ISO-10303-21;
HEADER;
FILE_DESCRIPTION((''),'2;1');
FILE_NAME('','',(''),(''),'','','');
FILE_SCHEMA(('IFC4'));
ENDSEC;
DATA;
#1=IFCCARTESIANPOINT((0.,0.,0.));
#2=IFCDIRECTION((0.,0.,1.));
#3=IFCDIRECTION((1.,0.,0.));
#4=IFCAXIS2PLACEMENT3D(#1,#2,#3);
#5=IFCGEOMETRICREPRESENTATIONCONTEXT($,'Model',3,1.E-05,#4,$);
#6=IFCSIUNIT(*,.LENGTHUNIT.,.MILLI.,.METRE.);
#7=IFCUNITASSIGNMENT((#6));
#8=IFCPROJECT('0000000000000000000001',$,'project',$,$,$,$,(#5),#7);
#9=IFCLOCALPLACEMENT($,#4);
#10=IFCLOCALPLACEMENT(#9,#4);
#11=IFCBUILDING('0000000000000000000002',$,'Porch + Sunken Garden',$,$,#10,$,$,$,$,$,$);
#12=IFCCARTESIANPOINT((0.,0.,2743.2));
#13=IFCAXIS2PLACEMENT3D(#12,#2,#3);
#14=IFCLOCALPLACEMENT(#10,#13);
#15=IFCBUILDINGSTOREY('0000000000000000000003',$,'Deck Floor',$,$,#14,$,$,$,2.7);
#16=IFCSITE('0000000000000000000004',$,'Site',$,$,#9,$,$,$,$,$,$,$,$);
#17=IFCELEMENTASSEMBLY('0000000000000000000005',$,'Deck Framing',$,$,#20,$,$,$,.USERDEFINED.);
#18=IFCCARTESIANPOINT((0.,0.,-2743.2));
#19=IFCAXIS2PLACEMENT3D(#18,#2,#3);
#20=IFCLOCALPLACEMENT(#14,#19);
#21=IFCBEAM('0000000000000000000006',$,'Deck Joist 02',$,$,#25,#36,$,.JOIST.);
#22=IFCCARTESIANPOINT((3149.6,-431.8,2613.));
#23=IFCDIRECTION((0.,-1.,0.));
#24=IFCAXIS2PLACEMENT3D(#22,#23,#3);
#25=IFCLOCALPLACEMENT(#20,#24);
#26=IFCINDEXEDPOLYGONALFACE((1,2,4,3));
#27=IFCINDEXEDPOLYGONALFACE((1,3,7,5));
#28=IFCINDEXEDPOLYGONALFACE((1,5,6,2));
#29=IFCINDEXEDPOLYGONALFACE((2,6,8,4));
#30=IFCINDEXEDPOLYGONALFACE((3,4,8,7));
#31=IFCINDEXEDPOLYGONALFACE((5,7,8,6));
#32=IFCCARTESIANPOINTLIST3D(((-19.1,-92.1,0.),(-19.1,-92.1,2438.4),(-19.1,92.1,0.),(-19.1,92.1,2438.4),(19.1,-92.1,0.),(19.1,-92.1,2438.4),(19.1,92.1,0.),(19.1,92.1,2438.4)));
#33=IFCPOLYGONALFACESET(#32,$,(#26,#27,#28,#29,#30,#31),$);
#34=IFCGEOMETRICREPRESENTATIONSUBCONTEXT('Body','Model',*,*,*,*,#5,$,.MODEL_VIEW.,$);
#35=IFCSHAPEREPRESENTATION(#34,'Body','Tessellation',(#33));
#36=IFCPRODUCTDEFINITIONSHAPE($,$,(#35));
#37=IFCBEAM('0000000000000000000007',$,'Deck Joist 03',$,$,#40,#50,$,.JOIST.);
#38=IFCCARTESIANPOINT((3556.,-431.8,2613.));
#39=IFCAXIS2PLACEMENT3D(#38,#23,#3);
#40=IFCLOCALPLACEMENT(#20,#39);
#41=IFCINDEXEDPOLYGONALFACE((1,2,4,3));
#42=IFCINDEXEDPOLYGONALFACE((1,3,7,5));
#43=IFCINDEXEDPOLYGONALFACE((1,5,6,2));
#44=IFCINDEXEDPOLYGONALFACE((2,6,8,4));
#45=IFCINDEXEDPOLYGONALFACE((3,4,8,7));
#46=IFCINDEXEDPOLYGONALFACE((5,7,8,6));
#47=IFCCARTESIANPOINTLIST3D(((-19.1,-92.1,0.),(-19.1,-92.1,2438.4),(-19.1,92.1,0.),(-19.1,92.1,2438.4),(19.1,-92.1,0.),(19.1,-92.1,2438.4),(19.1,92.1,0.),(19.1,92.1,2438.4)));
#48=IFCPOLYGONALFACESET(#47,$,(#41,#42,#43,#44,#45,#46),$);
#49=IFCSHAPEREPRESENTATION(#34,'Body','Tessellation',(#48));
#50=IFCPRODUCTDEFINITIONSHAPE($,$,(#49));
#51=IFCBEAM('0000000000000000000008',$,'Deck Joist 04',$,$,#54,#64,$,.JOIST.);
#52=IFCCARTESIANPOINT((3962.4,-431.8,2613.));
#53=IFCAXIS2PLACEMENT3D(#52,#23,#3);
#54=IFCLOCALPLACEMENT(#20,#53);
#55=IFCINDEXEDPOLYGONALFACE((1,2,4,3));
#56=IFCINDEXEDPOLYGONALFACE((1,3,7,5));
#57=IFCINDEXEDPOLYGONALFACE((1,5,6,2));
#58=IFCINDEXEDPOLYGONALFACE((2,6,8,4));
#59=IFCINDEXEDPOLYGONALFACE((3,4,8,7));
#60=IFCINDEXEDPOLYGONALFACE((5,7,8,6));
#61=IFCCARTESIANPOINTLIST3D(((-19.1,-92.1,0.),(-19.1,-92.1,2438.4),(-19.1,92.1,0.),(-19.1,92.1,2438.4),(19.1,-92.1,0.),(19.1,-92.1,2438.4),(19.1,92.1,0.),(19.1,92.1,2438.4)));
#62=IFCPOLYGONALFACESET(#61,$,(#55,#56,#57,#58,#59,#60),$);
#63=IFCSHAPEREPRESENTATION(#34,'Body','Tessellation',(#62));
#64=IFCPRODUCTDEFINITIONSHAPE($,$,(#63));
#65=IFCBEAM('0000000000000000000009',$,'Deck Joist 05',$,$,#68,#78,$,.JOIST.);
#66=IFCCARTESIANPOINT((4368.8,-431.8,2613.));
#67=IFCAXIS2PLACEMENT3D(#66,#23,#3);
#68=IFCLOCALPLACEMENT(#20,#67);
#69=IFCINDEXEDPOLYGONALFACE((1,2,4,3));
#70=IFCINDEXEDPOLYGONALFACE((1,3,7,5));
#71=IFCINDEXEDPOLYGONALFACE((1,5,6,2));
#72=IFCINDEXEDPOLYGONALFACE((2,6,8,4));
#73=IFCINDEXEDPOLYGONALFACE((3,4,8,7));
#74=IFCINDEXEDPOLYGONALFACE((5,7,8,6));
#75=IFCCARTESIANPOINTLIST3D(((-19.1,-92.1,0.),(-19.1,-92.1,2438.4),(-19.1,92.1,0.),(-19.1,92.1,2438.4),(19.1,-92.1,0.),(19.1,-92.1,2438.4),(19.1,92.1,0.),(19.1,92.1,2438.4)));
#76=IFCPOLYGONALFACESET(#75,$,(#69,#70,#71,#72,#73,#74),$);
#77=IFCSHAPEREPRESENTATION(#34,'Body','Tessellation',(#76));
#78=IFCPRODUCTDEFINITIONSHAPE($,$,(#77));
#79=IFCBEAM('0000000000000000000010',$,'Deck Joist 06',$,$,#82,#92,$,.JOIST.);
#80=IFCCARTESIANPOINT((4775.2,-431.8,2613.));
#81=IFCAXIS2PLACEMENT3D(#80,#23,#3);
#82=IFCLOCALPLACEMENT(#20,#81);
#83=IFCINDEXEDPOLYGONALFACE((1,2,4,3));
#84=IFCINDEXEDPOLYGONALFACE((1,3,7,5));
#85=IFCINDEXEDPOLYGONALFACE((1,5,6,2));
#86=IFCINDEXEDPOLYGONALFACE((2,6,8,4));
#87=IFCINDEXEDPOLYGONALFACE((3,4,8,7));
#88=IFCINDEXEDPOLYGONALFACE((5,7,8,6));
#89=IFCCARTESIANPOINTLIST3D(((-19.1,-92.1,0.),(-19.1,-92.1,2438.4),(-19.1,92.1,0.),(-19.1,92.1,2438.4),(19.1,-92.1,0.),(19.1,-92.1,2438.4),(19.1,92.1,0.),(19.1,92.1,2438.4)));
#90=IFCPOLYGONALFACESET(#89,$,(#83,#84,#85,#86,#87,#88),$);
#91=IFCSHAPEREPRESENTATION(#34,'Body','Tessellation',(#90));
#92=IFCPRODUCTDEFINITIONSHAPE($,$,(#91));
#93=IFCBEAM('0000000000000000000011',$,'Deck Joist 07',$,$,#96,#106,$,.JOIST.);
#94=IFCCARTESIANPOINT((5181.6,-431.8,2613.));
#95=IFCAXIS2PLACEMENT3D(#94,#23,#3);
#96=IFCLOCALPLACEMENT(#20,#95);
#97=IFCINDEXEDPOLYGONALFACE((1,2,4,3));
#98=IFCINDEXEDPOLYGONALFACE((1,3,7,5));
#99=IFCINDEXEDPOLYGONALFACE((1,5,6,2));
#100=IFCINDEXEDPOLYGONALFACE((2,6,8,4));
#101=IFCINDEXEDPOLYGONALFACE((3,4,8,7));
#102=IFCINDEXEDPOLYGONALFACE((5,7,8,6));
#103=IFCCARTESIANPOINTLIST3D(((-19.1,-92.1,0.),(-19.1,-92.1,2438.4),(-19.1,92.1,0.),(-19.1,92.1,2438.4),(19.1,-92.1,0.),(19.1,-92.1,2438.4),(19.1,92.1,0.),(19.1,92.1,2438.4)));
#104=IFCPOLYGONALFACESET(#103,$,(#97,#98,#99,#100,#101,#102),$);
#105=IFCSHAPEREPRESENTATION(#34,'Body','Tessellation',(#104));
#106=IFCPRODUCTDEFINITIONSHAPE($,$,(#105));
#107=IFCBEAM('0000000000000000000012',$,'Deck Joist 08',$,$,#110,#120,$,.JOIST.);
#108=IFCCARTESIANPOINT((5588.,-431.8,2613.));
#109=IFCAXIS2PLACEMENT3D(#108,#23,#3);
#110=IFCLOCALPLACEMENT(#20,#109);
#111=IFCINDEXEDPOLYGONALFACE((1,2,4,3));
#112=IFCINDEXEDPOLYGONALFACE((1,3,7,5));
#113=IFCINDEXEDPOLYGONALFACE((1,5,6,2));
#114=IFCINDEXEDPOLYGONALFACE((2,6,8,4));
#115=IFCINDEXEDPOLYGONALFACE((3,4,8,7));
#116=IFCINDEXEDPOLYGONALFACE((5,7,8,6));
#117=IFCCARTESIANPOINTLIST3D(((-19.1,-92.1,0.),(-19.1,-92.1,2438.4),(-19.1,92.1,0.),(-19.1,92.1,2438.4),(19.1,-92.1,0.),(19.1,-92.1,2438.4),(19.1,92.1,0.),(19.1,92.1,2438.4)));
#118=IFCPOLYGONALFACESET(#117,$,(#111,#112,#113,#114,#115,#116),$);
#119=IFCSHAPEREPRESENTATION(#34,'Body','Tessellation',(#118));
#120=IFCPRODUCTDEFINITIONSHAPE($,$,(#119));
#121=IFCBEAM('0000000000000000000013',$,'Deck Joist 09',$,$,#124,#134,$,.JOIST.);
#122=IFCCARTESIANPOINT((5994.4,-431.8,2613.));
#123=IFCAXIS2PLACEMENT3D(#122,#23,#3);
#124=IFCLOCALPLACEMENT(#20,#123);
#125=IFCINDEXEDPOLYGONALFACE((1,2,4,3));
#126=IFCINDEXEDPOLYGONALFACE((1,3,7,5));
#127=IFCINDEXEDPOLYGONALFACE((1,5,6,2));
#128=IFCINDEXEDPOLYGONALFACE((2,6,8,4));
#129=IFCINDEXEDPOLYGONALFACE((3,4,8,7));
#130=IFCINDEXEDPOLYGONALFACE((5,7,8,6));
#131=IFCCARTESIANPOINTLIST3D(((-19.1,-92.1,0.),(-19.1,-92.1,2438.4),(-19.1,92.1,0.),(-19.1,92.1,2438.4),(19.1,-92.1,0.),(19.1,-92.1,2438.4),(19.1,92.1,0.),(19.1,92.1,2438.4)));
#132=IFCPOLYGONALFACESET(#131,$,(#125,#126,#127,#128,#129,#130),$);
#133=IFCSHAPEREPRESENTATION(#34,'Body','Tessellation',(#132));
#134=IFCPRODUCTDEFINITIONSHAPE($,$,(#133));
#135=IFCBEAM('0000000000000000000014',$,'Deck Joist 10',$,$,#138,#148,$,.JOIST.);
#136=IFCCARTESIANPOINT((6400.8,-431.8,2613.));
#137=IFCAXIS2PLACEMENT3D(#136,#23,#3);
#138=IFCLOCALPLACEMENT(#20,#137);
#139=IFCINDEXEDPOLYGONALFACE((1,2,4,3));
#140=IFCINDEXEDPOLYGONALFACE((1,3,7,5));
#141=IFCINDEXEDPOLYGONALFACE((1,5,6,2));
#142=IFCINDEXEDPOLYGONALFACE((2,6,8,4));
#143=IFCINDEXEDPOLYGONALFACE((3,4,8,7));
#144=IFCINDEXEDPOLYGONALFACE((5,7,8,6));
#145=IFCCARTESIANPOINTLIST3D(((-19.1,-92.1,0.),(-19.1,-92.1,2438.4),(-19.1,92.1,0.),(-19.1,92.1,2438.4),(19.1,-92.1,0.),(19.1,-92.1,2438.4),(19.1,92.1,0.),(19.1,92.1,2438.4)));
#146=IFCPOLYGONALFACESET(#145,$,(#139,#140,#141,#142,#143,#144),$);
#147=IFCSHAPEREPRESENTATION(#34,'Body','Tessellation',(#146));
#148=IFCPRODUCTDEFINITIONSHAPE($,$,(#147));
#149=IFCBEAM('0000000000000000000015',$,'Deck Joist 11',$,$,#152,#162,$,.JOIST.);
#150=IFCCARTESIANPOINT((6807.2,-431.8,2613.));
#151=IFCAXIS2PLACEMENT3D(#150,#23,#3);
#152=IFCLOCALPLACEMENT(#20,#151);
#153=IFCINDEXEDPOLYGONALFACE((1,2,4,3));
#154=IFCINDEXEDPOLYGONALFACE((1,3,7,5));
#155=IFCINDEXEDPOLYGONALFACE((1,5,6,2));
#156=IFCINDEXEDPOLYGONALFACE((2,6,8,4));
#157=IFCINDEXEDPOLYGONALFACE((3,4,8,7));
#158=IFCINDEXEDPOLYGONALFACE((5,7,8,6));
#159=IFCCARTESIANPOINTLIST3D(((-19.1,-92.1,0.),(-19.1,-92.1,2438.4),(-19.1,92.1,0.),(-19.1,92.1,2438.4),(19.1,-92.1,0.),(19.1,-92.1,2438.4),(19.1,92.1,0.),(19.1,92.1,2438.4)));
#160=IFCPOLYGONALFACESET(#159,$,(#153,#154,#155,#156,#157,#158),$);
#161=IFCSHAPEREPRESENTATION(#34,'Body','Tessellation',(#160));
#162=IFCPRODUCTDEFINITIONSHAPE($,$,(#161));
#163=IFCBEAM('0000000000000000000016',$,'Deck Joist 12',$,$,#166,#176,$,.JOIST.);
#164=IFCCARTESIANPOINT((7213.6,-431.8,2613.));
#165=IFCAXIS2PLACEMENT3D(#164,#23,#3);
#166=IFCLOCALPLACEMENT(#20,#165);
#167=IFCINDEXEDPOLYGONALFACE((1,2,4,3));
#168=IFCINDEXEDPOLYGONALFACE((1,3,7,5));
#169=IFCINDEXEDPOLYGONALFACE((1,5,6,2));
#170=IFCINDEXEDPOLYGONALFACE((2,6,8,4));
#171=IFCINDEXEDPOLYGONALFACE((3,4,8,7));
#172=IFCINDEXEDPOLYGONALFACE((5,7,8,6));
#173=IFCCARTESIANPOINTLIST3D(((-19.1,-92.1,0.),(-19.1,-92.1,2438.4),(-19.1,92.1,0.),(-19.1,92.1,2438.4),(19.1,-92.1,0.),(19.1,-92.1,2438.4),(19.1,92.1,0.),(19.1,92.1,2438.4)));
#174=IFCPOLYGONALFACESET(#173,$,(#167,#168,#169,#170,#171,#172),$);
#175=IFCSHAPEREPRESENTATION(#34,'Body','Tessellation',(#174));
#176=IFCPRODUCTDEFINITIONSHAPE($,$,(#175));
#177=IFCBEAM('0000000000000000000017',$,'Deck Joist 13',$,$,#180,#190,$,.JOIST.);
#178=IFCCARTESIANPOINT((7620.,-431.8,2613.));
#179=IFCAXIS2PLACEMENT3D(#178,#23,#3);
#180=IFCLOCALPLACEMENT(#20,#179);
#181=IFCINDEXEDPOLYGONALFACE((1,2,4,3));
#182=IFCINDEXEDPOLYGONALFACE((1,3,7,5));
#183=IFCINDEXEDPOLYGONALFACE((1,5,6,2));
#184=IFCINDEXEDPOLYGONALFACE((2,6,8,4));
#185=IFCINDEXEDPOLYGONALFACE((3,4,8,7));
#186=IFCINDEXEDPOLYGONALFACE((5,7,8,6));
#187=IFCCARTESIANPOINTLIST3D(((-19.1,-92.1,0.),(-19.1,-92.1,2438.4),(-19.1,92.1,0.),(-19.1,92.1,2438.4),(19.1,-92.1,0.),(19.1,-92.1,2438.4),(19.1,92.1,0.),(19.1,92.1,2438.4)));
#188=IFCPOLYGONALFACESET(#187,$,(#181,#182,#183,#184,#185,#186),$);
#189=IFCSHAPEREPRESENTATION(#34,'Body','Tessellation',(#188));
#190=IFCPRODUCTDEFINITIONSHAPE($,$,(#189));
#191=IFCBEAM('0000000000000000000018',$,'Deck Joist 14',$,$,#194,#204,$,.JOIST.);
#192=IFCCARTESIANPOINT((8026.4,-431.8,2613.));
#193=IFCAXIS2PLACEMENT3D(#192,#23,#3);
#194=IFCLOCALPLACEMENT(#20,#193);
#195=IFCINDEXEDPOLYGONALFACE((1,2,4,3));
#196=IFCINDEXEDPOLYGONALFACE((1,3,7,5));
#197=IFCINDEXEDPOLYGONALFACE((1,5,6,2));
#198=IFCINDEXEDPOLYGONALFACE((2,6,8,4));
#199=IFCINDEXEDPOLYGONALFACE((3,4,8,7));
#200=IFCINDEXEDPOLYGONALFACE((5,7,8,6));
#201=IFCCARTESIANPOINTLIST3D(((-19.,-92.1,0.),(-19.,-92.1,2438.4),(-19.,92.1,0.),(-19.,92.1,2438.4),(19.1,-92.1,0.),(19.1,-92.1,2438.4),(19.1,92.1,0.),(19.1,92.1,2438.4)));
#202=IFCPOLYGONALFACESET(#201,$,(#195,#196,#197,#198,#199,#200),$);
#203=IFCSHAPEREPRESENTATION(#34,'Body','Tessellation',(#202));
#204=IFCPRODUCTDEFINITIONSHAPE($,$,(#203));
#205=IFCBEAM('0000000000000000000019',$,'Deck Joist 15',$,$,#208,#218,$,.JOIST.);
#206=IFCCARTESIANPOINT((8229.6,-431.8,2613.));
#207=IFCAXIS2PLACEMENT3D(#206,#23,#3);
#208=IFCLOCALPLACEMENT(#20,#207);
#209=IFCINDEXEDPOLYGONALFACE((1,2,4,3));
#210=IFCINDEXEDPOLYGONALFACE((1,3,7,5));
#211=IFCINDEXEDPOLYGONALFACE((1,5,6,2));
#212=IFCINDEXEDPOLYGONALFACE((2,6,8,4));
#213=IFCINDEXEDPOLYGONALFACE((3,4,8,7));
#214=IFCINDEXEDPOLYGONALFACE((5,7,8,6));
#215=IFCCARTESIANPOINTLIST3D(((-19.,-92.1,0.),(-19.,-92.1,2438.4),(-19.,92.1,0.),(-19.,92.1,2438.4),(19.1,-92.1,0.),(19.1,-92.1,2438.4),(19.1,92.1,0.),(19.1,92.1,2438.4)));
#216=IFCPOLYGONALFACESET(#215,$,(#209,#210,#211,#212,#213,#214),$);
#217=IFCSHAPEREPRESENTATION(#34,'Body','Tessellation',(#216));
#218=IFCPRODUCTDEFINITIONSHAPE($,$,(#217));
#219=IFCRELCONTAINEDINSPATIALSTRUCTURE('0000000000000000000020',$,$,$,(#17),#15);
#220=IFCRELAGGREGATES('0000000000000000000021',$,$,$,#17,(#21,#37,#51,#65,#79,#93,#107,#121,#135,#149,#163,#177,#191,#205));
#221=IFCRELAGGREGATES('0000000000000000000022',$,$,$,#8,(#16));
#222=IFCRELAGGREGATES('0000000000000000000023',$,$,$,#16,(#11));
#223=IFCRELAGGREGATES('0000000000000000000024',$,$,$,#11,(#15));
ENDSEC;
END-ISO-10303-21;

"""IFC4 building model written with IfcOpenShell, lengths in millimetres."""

from ifc_helpers import new_model, si_unit, frame, origin_with_axes, origin_2d, place, context, subcontext, project, spatial, rectangle, extrude, element, aggregate, save


model = new_model("IFC4")

# Units and contexts
model_context = context("Model", 3, precision=1e-05, world=origin_with_axes())
body_context = subcontext(model_context, "Body", "Model", "MODEL_VIEW")
ifc_project = project(units=[si_unit("LENGTHUNIT", "METRE", prefix="MILLI")], contexts=[model_context])

# Site, building, storey
site_placement = place(None, origin_with_axes())
site = spatial("IfcSite", under=ifc_project, at=site_placement, Name="Site")
building_placement = place(site_placement, origin_with_axes())
building = spatial("IfcBuilding", under=site, at=building_placement, Name="Porch + Sunken Garden")
storey_placement = place(building_placement, frame((0.0, 0.0, 2743.2), z_axis=(0.0, 0.0, 1.0), x_axis=(1.0, 0.0, 0.0)))
storey = spatial("IfcBuildingStorey", under=building, at=storey_placement, Name="Deck Floor", Elevation=2.7)

# Element assembly, beams
assembly_placement = place(storey_placement, frame((0.0, 0.0, -2743.2), z_axis=(0.0, 0.0, 1.0), x_axis=(1.0, 0.0, 0.0)))
assembly = element("IfcElementAssembly", 1, at=assembly_placement, inside=storey, Name="Deck Framing", PredefinedType="USERDEFINED")
beam_1_placement = place(assembly_placement, frame((3149.6, -431.8, 2613.0), z_axis=(0.0, -1.0, 0.0), x_axis=(1.0, 0.0, 0.0)))
beam_1 = element("IfcBeam", 2, at=beam_1_placement, Name="Deck Joist 02", PredefinedType="JOIST", context=body_context, shape_type="SweptSolid", body=[
    extrude(rectangle(XDim=38.1, YDim=184.2, at=origin_2d()), origin_with_axes(), (0.0, 0.0, 1.0), 2438.4),
])
beam_2_placement = place(assembly_placement, frame((3556.0, -431.8, 2613.0), z_axis=(0.0, -1.0, 0.0), x_axis=(1.0, 0.0, 0.0)))
beam_2 = element("IfcBeam", 3, at=beam_2_placement, Name="Deck Joist 03", PredefinedType="JOIST", context=body_context, shape_type="SweptSolid", body=[
    extrude(rectangle(XDim=38.1, YDim=184.2, at=origin_2d()), origin_with_axes(), (0.0, 0.0, 1.0), 2438.4),
])
beam_3_placement = place(assembly_placement, frame((3962.4, -431.8, 2613.0), z_axis=(0.0, -1.0, 0.0), x_axis=(1.0, 0.0, 0.0)))
beam_3 = element("IfcBeam", 4, at=beam_3_placement, Name="Deck Joist 04", PredefinedType="JOIST", context=body_context, shape_type="SweptSolid", body=[
    extrude(rectangle(XDim=38.1, YDim=184.2, at=origin_2d()), origin_with_axes(), (0.0, 0.0, 1.0), 2438.4),
])
beam_4_placement = place(assembly_placement, frame((4368.8, -431.8, 2613.0), z_axis=(0.0, -1.0, 0.0), x_axis=(1.0, 0.0, 0.0)))
beam_4 = element("IfcBeam", 5, at=beam_4_placement, Name="Deck Joist 05", PredefinedType="JOIST", context=body_context, shape_type="SweptSolid", body=[
    extrude(rectangle(XDim=38.1, YDim=184.2, at=origin_2d()), origin_with_axes(), (0.0, 0.0, 1.0), 2438.4),
])
beam_5_placement = place(assembly_placement, frame((4775.2, -431.8, 2613.0), z_axis=(0.0, -1.0, 0.0), x_axis=(1.0, 0.0, 0.0)))
beam_5 = element("IfcBeam", 6, at=beam_5_placement, Name="Deck Joist 06", PredefinedType="JOIST", context=body_context, shape_type="SweptSolid", body=[
    extrude(rectangle(XDim=38.1, YDim=184.2, at=origin_2d()), origin_with_axes(), (0.0, 0.0, 1.0), 2438.4),
])
beam_6_placement = place(assembly_placement, frame((5181.6, -431.8, 2613.0), z_axis=(0.0, -1.0, 0.0), x_axis=(1.0, 0.0, 0.0)))
beam_6 = element("IfcBeam", 7, at=beam_6_placement, Name="Deck Joist 07", PredefinedType="JOIST", context=body_context, shape_type="SweptSolid", body=[
    extrude(rectangle(XDim=38.1, YDim=184.2, at=origin_2d()), origin_with_axes(), (0.0, 0.0, 1.0), 2438.4),
])
beam_7_placement = place(assembly_placement, frame((5588.0, -431.8, 2613.0), z_axis=(0.0, -1.0, 0.0), x_axis=(1.0, 0.0, 0.0)))
beam_7 = element("IfcBeam", 8, at=beam_7_placement, Name="Deck Joist 08", PredefinedType="JOIST", context=body_context, shape_type="SweptSolid", body=[
    extrude(rectangle(XDim=38.1, YDim=184.2, at=origin_2d()), origin_with_axes(), (0.0, 0.0, 1.0), 2438.4),
])
beam_8_placement = place(assembly_placement, frame((5994.4, -431.8, 2613.0), z_axis=(0.0, -1.0, 0.0), x_axis=(1.0, 0.0, 0.0)))
beam_8 = element("IfcBeam", 9, at=beam_8_placement, Name="Deck Joist 09", PredefinedType="JOIST", context=body_context, shape_type="SweptSolid", body=[
    extrude(rectangle(XDim=38.1, YDim=184.2, at=origin_2d()), origin_with_axes(), (0.0, 0.0, 1.0), 2438.4),
])
beam_9_placement = place(assembly_placement, frame((6400.8, -431.8, 2613.0), z_axis=(0.0, -1.0, 0.0), x_axis=(1.0, 0.0, 0.0)))
beam_9 = element("IfcBeam", 10, at=beam_9_placement, Name="Deck Joist 10", PredefinedType="JOIST", context=body_context, shape_type="SweptSolid", body=[
    extrude(rectangle(XDim=38.1, YDim=184.2, at=origin_2d()), origin_with_axes(), (0.0, 0.0, 1.0), 2438.4),
])
beam_10_placement = place(assembly_placement, frame((6807.2, -431.8, 2613.0), z_axis=(0.0, -1.0, 0.0), x_axis=(1.0, 0.0, 0.0)))
beam_10 = element("IfcBeam", 11, at=beam_10_placement, Name="Deck Joist 11", PredefinedType="JOIST", context=body_context, shape_type="SweptSolid", body=[
    extrude(rectangle(XDim=38.1, YDim=184.2, at=origin_2d()), origin_with_axes(), (0.0, 0.0, 1.0), 2438.4),
])
beam_11_placement = place(assembly_placement, frame((7213.6, -431.8, 2613.0), z_axis=(0.0, -1.0, 0.0), x_axis=(1.0, 0.0, 0.0)))
beam_11 = element("IfcBeam", 12, at=beam_11_placement, Name="Deck Joist 12", PredefinedType="JOIST", context=body_context, shape_type="SweptSolid", body=[
    extrude(rectangle(XDim=38.1, YDim=184.2, at=origin_2d()), origin_with_axes(), (0.0, 0.0, 1.0), 2438.4),
])
beam_12_placement = place(assembly_placement, frame((7620.0, -431.8, 2613.0), z_axis=(0.0, -1.0, 0.0), x_axis=(1.0, 0.0, 0.0)))
beam_12 = element("IfcBeam", 13, at=beam_12_placement, Name="Deck Joist 13", PredefinedType="JOIST", context=body_context, shape_type="SweptSolid", body=[
    extrude(rectangle(XDim=38.1, YDim=184.2, at=origin_2d()), origin_with_axes(), (0.0, 0.0, 1.0), 2438.4),
])
beam_13_placement = place(assembly_placement, frame((8026.4, -431.8, 2613.0), z_axis=(0.0, -1.0, 0.0), x_axis=(1.0, 0.0, 0.0)))
beam_13 = element("IfcBeam", 14, at=beam_13_placement, Name="Deck Joist 14", PredefinedType="JOIST", context=body_context, shape_type="SweptSolid", body=[
    extrude(rectangle(XDim=38.1, YDim=184.2, at=origin_2d()), origin_with_axes(), (0.0, 0.0, 1.0), 2438.4),
])
beam_14_placement = place(assembly_placement, frame((8229.6, -431.8, 2613.0), z_axis=(0.0, -1.0, 0.0), x_axis=(1.0, 0.0, 0.0)))
beam_14 = element("IfcBeam", 15, at=beam_14_placement, Name="Deck Joist 15", PredefinedType="JOIST", context=body_context, shape_type="SweptSolid", body=[
    extrude(rectangle(XDim=38.1, YDim=184.2, at=origin_2d()), origin_with_axes(), (0.0, 0.0, 1.0), 2438.4),
])
aggregate(assembly, [beam_1, beam_2, beam_3, beam_4, beam_5, beam_6, beam_7, beam_8, beam_9, beam_10, beam_11, beam_12, beam_13, beam_14])

save(model, "model.ifc")
